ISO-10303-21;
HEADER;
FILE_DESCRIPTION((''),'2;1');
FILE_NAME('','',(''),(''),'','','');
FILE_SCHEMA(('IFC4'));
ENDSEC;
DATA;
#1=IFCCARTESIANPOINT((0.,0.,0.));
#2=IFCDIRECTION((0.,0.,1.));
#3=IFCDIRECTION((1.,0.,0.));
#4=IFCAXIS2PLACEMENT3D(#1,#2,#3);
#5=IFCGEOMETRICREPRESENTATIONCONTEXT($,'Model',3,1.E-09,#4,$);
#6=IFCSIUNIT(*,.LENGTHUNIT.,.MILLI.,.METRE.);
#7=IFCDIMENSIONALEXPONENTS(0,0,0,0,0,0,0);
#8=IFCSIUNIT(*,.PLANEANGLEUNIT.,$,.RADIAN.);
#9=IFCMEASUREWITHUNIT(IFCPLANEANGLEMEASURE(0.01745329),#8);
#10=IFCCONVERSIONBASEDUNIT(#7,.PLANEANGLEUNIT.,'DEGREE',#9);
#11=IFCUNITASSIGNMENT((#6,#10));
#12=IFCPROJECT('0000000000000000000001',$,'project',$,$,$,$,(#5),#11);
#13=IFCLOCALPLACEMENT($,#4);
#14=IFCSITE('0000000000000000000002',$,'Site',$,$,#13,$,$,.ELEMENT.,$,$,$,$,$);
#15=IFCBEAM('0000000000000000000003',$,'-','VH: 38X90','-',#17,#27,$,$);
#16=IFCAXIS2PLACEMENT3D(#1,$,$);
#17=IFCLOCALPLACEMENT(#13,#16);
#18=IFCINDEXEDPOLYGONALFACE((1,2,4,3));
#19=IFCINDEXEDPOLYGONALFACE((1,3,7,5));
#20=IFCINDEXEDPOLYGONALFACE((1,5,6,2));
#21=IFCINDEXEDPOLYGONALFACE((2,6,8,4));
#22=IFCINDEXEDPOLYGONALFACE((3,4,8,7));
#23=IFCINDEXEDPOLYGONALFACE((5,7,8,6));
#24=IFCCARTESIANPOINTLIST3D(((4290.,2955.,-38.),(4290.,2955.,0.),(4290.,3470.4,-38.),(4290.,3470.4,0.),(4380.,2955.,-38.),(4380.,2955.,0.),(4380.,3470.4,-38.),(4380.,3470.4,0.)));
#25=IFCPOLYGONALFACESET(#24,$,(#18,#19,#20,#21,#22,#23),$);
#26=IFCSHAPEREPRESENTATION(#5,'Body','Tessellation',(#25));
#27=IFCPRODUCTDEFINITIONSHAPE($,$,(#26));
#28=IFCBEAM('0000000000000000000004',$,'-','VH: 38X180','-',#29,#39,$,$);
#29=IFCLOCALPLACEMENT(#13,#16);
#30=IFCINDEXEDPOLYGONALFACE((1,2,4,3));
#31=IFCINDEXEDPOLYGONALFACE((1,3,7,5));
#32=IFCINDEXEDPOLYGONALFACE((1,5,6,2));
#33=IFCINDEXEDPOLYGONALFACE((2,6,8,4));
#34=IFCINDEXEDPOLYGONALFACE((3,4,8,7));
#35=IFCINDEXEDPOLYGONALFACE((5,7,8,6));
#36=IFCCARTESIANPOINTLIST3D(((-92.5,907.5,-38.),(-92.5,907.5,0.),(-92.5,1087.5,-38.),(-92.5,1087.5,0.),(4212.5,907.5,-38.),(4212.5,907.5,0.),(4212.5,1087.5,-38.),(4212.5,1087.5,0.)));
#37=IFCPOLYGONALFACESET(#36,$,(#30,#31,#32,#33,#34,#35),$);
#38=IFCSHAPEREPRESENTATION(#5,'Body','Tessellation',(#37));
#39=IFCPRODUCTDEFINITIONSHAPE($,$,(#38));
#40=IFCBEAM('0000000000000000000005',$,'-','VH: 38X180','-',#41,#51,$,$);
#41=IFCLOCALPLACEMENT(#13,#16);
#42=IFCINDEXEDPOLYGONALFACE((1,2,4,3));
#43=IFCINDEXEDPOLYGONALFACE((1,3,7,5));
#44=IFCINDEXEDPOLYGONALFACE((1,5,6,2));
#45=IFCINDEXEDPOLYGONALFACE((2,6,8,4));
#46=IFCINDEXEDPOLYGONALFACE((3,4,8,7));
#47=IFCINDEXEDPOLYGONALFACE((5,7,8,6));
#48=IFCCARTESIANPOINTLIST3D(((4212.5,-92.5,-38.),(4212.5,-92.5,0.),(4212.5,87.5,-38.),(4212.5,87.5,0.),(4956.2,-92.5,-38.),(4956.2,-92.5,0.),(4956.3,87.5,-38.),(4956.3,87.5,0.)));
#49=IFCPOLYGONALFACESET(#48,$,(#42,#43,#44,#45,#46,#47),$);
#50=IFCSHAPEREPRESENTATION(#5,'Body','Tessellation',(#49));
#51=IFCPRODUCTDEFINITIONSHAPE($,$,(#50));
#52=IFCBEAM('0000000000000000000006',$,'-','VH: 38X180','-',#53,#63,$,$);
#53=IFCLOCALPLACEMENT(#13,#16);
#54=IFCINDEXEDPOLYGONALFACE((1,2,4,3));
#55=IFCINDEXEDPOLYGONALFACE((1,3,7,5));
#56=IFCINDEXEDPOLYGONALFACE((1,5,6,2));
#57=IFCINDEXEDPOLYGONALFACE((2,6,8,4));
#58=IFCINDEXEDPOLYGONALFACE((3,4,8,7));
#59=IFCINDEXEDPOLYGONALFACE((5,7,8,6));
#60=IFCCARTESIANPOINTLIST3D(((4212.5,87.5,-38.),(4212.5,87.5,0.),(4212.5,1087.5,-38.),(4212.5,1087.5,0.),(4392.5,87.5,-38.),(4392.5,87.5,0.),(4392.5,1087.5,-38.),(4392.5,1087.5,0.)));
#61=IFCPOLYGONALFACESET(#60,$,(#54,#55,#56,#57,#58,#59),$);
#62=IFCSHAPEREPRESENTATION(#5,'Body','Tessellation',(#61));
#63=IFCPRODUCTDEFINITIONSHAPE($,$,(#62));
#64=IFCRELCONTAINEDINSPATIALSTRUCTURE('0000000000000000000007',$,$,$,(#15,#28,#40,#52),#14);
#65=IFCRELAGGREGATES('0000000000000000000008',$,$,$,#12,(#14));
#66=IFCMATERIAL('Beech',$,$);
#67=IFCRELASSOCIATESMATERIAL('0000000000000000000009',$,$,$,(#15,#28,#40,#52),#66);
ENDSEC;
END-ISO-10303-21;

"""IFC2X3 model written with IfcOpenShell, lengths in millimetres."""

from ifc_helpers import new_model, entity, si_unit, converted_unit, frame, origin, origin_with_axes, origin_2d, place, context, project, spatial, rectangle, extrude, material, element, save


model = new_model("IFC2X3")

# Units and contexts
model_context = context("Model", 3, precision=1e-09, world=origin_with_axes())
ifc_project = project(units=[si_unit("LENGTHUNIT", "METRE", prefix="MILLI"), converted_unit("PLANEANGLEUNIT", "DEGREE", entity("IfcPlaneAngleMeasure", 0.01745329), si_unit("PLANEANGLEUNIT", "RADIAN"), dimensions=[0, 0, 0, 0, 0, 0, 0])], contexts=[model_context])

# Site
site_placement = place(None, origin_with_axes())
site = spatial("IfcSite", under=ifc_project, at=site_placement, Name="Site", CompositionType="ELEMENT")

# Shared definitions
ifc_material = material(Name="Beech")

# Beams
beam_1_placement = place(None, frame((4335.0, 2955.0, -19.0), z_axis=(-0.000048, -1.0, 0.0), x_axis=(0.0, 0.0, -1.0)))
element("IfcBeam", 1, at=beam_1_placement, inside=site, material=ifc_material, Name="-", Description="VH: 38X90", ObjectType="-", context=model_context, shape_type="SweptSolid", body=[
    extrude(rectangle(XDim=38.0, YDim=90.0, at=origin_2d()), origin(), (0.0, 0.0, -1.0), 515.4),
])
beam_2_placement = place(None, frame((4212.5, 997.5, -19.0), z_axis=(1.0, -0.000003, 0.0), x_axis=(0.0, 0.0, -1.0)))
element("IfcBeam", 2, at=beam_2_placement, inside=site, material=ifc_material, Name="-", Description="VH: 38X180", ObjectType="-", context=model_context, shape_type="SweptSolid", body=[
    extrude(rectangle(XDim=38.0, YDim=180.0, at=origin_2d()), origin(), (0.0, 0.0, -1.0), 4305.0),
])
beam_3_placement = place(None, frame((4956.2, -2.5, -19.0), z_axis=(1.0, -0.000003, 0.0), x_axis=(0.0, 0.0, -1.0)))
element("IfcBeam", 3, at=beam_3_placement, inside=site, material=ifc_material, Name="-", Description="VH: 38X180", ObjectType="-", context=model_context, shape_type="SweptSolid", body=[
    extrude(rectangle(XDim=38.0, YDim=180.0, at=origin_2d()), origin(), (0.0, 0.0, -1.0), 743.7),
])
beam_4_placement = place(None, frame((4302.5, 1087.5, -19.0), z_axis=(0.000013, -1.0, 0.0), x_axis=(0.0, 0.0, 1.0)))
element("IfcBeam", 4, at=beam_4_placement, inside=site, material=ifc_material, Name="-", Description="VH: 38X180", ObjectType="-", context=model_context, shape_type="SweptSolid", body=[
    extrude(rectangle(XDim=38.0, YDim=180.0, at=origin_2d()), origin(), (0.0, 0.0, 1.0), 1000.0),
])

save(model, "model.ifc")
